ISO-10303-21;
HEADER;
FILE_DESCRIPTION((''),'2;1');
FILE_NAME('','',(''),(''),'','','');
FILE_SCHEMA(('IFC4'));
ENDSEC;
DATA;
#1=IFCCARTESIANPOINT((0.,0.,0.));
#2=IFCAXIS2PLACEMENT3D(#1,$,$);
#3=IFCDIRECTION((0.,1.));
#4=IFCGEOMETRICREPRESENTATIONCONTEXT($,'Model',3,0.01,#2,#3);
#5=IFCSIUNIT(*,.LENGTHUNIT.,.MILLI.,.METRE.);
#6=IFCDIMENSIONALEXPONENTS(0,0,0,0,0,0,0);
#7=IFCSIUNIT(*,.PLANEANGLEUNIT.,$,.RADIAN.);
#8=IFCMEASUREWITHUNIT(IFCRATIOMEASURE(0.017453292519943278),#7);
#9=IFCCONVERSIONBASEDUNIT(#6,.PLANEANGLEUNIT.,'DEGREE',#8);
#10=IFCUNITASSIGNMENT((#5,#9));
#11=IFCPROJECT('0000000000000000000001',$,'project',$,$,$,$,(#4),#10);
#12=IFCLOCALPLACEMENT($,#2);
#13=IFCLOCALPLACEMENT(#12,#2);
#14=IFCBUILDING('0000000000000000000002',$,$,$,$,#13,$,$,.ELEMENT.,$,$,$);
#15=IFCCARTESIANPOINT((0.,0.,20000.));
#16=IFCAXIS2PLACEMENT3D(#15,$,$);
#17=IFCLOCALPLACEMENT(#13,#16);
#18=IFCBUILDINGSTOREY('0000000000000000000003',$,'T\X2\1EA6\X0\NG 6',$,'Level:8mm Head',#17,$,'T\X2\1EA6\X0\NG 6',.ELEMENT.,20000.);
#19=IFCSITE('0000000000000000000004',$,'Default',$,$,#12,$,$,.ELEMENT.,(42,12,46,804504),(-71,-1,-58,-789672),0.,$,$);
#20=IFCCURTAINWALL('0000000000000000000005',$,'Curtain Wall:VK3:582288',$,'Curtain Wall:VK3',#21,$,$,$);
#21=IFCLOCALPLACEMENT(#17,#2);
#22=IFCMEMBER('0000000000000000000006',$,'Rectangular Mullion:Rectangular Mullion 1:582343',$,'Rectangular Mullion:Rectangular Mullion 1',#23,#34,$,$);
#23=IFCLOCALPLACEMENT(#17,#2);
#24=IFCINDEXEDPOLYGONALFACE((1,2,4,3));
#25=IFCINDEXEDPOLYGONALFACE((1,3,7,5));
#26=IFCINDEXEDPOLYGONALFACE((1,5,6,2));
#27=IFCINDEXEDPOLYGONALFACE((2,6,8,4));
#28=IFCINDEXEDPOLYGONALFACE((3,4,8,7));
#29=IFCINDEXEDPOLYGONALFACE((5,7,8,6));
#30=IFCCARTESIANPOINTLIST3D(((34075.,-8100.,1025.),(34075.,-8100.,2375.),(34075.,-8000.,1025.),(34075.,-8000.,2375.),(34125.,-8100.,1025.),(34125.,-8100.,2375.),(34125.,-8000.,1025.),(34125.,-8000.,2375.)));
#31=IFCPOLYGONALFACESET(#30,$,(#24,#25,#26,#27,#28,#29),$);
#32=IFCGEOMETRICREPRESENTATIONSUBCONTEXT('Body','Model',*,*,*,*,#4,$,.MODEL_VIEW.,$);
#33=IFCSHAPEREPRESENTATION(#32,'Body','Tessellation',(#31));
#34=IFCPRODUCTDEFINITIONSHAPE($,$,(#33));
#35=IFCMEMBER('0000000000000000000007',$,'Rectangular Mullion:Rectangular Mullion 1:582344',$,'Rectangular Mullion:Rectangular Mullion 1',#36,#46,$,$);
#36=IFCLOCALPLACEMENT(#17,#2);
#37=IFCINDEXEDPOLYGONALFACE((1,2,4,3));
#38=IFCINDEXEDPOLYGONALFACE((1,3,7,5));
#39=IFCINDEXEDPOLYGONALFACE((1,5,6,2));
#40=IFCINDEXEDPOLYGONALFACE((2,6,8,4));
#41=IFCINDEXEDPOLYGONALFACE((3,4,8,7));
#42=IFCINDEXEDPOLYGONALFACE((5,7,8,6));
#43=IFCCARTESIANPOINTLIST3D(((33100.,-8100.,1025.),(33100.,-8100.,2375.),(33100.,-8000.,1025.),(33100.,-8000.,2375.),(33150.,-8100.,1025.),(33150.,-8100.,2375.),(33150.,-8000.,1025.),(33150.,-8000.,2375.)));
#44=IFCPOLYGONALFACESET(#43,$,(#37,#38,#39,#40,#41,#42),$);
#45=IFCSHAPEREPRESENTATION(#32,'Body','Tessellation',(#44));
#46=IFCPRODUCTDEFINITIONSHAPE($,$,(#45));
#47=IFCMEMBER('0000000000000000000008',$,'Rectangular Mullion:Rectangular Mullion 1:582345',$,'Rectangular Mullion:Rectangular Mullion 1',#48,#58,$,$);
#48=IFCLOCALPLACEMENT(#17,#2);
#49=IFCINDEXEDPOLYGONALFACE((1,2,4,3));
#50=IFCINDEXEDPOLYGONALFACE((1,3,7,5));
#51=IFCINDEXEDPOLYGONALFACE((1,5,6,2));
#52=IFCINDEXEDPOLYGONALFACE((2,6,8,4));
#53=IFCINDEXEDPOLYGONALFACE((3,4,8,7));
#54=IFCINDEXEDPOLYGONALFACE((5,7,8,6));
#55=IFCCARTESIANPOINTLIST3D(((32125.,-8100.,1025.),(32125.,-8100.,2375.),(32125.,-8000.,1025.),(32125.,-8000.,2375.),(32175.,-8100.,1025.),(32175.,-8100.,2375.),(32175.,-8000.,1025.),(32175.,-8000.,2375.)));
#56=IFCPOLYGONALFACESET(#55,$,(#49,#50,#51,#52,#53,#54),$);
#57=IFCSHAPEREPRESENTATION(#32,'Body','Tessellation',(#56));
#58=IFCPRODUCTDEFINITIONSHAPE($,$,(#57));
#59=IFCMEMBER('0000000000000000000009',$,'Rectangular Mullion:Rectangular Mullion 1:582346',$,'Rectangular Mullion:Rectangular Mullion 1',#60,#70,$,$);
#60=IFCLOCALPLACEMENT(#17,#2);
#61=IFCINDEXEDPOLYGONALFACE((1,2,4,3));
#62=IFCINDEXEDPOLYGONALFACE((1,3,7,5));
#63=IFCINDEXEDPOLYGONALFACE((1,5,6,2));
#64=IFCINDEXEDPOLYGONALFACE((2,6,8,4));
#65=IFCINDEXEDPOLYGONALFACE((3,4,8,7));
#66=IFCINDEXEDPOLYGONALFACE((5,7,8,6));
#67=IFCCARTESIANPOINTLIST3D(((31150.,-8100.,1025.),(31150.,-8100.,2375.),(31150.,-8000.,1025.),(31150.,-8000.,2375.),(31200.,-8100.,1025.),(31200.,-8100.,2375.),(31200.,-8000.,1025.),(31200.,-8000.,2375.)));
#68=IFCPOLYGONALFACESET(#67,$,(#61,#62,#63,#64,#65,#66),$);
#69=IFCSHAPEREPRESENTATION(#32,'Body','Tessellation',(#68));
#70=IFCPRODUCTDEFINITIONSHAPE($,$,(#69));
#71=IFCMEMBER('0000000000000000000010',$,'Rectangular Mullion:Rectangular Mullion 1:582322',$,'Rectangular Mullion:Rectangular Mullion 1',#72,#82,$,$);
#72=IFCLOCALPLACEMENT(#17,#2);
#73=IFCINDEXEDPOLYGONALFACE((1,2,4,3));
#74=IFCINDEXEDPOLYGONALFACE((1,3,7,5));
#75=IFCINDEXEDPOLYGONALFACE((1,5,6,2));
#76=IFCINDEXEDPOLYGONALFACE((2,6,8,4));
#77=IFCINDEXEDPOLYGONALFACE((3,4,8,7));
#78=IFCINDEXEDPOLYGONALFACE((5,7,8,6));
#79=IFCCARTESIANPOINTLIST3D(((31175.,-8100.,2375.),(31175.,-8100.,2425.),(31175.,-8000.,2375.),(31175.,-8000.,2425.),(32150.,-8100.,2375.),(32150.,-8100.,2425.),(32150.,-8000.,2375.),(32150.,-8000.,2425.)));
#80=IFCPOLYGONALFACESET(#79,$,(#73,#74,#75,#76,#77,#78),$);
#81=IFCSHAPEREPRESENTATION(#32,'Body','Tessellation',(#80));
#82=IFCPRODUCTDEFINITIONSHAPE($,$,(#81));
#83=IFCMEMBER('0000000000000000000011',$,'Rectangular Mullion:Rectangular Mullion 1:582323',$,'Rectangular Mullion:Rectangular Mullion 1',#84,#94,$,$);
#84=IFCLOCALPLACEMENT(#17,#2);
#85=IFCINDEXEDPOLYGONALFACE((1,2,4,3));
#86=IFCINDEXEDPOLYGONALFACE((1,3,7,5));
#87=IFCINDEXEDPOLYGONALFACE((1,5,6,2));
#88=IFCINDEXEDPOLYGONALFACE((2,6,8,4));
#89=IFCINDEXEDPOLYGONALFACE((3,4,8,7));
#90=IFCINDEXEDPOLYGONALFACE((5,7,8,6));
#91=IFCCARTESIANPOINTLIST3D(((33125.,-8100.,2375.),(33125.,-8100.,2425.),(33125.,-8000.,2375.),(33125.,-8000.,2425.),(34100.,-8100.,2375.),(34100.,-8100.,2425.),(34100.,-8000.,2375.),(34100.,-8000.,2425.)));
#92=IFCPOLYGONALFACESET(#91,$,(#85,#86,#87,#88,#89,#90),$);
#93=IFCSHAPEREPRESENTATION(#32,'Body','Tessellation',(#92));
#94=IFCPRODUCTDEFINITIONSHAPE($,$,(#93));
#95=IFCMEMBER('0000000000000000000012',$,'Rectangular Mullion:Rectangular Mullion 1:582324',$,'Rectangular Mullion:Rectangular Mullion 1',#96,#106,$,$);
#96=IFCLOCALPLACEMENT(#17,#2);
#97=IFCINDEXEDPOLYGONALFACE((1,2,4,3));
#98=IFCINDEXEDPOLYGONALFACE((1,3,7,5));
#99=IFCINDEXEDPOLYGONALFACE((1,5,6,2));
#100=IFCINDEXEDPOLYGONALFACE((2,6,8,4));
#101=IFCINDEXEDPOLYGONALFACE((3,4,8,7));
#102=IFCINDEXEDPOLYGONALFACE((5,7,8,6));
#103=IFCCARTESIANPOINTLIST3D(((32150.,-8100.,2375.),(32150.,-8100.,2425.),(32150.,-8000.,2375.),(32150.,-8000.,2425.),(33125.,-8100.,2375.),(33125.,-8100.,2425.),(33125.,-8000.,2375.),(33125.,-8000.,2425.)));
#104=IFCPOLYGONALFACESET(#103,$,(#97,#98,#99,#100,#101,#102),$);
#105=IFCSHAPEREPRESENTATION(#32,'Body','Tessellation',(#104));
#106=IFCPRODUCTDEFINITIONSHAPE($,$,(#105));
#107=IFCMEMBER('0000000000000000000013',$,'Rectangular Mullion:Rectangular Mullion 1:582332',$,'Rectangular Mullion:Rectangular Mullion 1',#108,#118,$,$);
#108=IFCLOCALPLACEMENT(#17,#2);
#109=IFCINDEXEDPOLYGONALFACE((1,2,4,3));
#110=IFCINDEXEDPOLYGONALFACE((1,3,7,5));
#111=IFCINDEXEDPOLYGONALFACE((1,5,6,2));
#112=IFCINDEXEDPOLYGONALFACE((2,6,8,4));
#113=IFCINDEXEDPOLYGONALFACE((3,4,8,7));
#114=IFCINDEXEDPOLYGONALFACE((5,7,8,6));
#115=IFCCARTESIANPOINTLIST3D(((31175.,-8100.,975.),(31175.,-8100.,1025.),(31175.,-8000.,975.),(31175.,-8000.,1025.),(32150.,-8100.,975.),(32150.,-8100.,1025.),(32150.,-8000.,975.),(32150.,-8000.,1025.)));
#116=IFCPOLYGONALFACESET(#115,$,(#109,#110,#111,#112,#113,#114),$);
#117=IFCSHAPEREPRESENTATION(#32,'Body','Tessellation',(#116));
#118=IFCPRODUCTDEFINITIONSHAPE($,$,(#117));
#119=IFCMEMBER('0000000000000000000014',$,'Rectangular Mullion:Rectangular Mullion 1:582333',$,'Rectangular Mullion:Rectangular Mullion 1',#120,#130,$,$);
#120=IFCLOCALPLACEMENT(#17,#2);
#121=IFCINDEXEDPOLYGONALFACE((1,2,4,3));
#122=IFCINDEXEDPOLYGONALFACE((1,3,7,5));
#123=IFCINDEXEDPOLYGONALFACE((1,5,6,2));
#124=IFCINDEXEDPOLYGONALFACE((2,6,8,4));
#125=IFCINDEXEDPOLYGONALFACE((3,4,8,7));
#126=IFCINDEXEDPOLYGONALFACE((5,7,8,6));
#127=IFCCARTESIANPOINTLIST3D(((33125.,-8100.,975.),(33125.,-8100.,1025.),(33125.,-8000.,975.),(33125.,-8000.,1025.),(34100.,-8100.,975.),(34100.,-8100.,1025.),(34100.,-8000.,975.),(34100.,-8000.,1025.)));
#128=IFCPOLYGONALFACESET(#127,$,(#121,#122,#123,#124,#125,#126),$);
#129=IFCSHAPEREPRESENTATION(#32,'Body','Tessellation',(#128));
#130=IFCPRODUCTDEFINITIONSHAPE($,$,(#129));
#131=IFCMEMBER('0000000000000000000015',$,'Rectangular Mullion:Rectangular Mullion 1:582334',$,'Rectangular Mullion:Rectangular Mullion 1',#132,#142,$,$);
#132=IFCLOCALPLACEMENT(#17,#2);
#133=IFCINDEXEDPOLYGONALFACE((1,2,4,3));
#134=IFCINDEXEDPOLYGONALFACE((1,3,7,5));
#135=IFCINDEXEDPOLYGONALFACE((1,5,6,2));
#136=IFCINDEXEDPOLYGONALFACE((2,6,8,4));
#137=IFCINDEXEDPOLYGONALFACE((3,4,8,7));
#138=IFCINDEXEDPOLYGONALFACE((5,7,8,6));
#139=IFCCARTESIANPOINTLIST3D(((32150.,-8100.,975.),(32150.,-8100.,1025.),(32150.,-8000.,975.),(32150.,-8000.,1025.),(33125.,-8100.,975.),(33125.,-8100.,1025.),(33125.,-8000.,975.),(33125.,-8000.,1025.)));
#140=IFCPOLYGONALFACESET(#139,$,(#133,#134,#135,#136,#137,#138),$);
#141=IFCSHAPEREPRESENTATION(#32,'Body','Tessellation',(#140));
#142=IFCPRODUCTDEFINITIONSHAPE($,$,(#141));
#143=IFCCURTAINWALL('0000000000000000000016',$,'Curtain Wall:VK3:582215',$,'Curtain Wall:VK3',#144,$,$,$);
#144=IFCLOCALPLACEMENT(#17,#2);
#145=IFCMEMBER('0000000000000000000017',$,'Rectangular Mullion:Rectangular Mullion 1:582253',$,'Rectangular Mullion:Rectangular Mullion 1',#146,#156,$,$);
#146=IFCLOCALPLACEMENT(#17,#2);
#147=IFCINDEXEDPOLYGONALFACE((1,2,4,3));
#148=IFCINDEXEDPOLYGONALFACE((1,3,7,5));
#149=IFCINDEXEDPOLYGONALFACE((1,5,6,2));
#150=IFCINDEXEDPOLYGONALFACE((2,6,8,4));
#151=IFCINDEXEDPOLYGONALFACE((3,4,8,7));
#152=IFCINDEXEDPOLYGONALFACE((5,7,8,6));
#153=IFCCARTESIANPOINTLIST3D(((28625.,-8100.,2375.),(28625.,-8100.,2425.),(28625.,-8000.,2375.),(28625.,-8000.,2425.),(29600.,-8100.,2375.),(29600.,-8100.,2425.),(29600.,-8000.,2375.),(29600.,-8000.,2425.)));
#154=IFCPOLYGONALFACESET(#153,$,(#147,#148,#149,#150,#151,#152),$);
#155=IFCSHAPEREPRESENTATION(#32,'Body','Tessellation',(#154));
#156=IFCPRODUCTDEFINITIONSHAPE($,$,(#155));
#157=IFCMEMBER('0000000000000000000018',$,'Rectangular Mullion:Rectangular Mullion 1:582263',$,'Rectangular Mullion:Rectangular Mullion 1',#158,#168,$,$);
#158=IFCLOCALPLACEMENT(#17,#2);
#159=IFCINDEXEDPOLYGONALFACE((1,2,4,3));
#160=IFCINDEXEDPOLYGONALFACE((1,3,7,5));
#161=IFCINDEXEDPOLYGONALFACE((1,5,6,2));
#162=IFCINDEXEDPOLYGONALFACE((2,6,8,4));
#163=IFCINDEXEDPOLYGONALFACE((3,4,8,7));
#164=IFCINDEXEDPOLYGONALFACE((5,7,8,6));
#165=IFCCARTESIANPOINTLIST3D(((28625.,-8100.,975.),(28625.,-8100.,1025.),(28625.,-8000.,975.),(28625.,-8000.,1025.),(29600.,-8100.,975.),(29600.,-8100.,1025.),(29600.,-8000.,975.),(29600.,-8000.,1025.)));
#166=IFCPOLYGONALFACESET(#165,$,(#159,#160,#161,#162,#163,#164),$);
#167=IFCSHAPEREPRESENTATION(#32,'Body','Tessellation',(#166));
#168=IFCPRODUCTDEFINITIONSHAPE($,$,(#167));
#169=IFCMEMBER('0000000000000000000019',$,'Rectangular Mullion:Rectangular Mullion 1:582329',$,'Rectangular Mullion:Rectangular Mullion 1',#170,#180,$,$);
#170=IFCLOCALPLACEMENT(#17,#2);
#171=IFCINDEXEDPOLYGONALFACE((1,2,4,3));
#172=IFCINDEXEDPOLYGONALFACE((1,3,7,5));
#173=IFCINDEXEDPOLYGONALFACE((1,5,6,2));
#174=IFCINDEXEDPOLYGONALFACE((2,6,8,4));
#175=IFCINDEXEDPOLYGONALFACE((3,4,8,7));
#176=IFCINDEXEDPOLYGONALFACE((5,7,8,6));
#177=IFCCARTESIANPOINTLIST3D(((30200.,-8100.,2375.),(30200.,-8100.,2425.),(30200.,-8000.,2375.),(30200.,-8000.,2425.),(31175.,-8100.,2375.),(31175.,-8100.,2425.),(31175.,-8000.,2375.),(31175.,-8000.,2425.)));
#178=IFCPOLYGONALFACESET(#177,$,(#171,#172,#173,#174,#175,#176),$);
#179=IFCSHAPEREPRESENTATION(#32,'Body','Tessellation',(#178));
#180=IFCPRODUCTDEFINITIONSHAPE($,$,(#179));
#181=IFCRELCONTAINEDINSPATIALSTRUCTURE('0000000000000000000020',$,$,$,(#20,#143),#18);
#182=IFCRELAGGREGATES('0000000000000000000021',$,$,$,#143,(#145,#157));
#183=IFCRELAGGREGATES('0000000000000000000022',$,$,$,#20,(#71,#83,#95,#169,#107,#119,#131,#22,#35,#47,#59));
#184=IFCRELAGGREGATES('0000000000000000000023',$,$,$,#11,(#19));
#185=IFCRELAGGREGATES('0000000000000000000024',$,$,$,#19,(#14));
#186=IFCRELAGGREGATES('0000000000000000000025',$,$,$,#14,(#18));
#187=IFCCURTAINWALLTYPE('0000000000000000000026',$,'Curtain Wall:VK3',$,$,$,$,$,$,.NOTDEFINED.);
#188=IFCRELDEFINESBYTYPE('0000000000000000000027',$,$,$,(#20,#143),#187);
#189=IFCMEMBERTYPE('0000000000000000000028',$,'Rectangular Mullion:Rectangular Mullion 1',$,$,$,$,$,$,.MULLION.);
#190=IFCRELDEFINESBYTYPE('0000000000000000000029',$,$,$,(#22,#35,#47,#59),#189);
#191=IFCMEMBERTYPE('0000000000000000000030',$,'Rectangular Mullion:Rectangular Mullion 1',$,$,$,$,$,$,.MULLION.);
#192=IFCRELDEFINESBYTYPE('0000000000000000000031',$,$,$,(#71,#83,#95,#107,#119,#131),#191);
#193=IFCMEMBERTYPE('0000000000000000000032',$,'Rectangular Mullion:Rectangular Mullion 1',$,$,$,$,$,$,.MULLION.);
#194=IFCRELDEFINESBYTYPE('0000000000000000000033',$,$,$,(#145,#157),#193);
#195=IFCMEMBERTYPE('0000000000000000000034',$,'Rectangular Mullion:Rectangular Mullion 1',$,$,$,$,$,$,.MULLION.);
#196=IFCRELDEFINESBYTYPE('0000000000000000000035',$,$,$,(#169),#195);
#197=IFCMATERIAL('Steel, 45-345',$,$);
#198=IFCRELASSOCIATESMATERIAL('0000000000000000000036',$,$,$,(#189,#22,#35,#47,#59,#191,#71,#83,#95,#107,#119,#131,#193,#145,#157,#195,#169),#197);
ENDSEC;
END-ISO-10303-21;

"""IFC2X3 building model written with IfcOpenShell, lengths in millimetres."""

from ifc_helpers import new_model, entity, si_unit, converted_unit, direction, frame, origin, origin_2d_with_axis, place, context, subcontext, project, spatial, rectangle, extrude, source, transform, mapped, material, type_object, type_shapes, element, aggregate, save


model = new_model("IFC2X3")

# Units and contexts
model_context = context("Model", 3, precision=0.01, world=origin(), true_north=direction((0.0, 1.0)))
body_context = subcontext(model_context, "Body", "Model", "MODEL_VIEW")
ifc_project = project(units=[si_unit("LENGTHUNIT", "METRE", prefix="MILLI"), converted_unit("PLANEANGLEUNIT", "DEGREE", entity("IfcRatioMeasure", 0.017453292519943278), si_unit("PLANEANGLEUNIT", "RADIAN"), dimensions=[0, 0, 0, 0, 0, 0, 0])], contexts=[model_context])

# Site, building, storey
site_placement = place(None, origin())
site = spatial("IfcSite", under=ifc_project, at=site_placement, Name="Default", CompositionType="ELEMENT", RefLatitude=(42, 12, 46, 804504), RefLongitude=(-71, -1, -58, -789672), RefElevation=0.0)
building_placement = place(site_placement, origin())
building = spatial("IfcBuilding", under=site, at=building_placement, CompositionType="ELEMENT")
storey_placement = place(building_placement, frame((0.0, 0.0, 20000.0)))
storey = spatial("IfcBuildingStorey", under=building, at=storey_placement, Name="TẦNG 6", ObjectType="Level:8mm Head", LongName="TẦNG 6", CompositionType="ELEMENT", Elevation=20000.0)

# Curtain walls, members
curtain_wall_type = type_object("IfcCurtainWallType", Name="Curtain Wall:VK3", PredefinedType="NOTDEFINED")
curtain_wall_1_placement = place(storey_placement, frame((0.0, 0.0, -20000.0)))
curtain_wall_1 = element("IfcCurtainWall", 1, at=curtain_wall_1_placement, inside=storey, type_object=curtain_wall_type, Name="Curtain Wall:VK3:582288", ObjectType="Curtain Wall:VK3")
ifc_material_1 = material(Name="Steel, 45-345")
member_type_1 = type_object("IfcMemberType", Name="Rectangular Mullion:Rectangular Mullion 1", PredefinedType="MULLION", material=ifc_material_1)
shared_shape_1 = source(origin(), body_context, "Body", "SweptSolid", [
    extrude(rectangle(XDim=100.0, YDim=50.0, at=origin_2d_with_axis()), frame((0.0, 50.0, -1350.0), z_axis=(0.0, 0.0, 1.0), x_axis=(0.0, -1.0, 0.0)), (0.0, 0.0, 1.0), 1350.0),
])
type_shapes(member_type_1, [shared_shape_1])
member_1_placement = place(curtain_wall_1_placement, frame((34100.0, -8000.0, 21025.0), z_axis=(0.0, 0.0, -1.0), x_axis=(1.0, 0.0, 0.0)))
member_1 = element("IfcMember", 2, at=member_1_placement, type_object=member_type_1, material=ifc_material_1, Name="Rectangular Mullion:Rectangular Mullion 1:582343", ObjectType="Rectangular Mullion:Rectangular Mullion 1", context=body_context, shape_type="MappedRepresentation", body=[
    mapped(shared_shape_1, transform((0.0, 0.0, 0.0), scale=1.0)),
])
member_2_placement = place(curtain_wall_1_placement, frame((33125.0, -8000.0, 21025.0), z_axis=(0.0, 0.0, -1.0), x_axis=(1.0, 0.0, 0.0)))
member_2 = element("IfcMember", 3, at=member_2_placement, type_object=member_type_1, material=ifc_material_1, Name="Rectangular Mullion:Rectangular Mullion 1:582344", ObjectType="Rectangular Mullion:Rectangular Mullion 1", context=body_context, shape_type="MappedRepresentation", body=[
    mapped(shared_shape_1, transform((0.0, 0.0, 0.0), scale=1.0)),
])
member_3_placement = place(curtain_wall_1_placement, frame((32150.0, -8000.0, 21025.0), z_axis=(0.0, 0.0, -1.0), x_axis=(1.0, 0.0, 0.0)))
member_3 = element("IfcMember", 4, at=member_3_placement, type_object=member_type_1, material=ifc_material_1, Name="Rectangular Mullion:Rectangular Mullion 1:582345", ObjectType="Rectangular Mullion:Rectangular Mullion 1", context=body_context, shape_type="MappedRepresentation", body=[
    mapped(shared_shape_1, transform((0.0, 0.0, 0.0), scale=1.0)),
])
member_4_placement = place(curtain_wall_1_placement, frame((31175.0, -8000.0, 21025.0), z_axis=(0.0, 0.0, -1.0), x_axis=(1.0, 0.0, 0.0)))
member_4 = element("IfcMember", 5, at=member_4_placement, type_object=member_type_1, material=ifc_material_1, Name="Rectangular Mullion:Rectangular Mullion 1:582346", ObjectType="Rectangular Mullion:Rectangular Mullion 1", context=body_context, shape_type="MappedRepresentation", body=[
    mapped(shared_shape_1, transform((0.0, 0.0, 0.0), scale=1.0)),
])
member_type_2 = type_object("IfcMemberType", Name="Rectangular Mullion:Rectangular Mullion 1", PredefinedType="MULLION", material=ifc_material_1)
shared_shape_2 = source(origin(), body_context, "Body", "SweptSolid", [
    extrude(rectangle(XDim=100.0, YDim=50.0, at=origin_2d_with_axis()), frame((0.0, 50.0, -975.0), z_axis=(0.0, 0.0, 1.0), x_axis=(0.0, -1.0, 0.0)), (0.0, 0.0, 1.0), 975.0),
])
type_shapes(member_type_2, [shared_shape_2])
member_5_placement = place(curtain_wall_1_placement, frame((32150.0, -8000.0, 22400.0), z_axis=(1.0, 0.0, 0.0), x_axis=(0.0, 0.0, 1.0)))
member_5 = element("IfcMember", 6, at=member_5_placement, type_object=member_type_2, material=ifc_material_1, Name="Rectangular Mullion:Rectangular Mullion 1:582322", ObjectType="Rectangular Mullion:Rectangular Mullion 1", context=body_context, shape_type="MappedRepresentation", body=[
    mapped(shared_shape_2, transform((0.0, 0.0, 0.0), scale=1.0)),
])
member_6_placement = place(curtain_wall_1_placement, frame((34100.0, -8000.0, 22400.0), z_axis=(1.0, 0.0, 0.0), x_axis=(0.0, 0.0, 1.0)))
member_6 = element("IfcMember", 7, at=member_6_placement, type_object=member_type_2, material=ifc_material_1, Name="Rectangular Mullion:Rectangular Mullion 1:582323", ObjectType="Rectangular Mullion:Rectangular Mullion 1", context=body_context, shape_type="MappedRepresentation", body=[
    mapped(shared_shape_2, transform((0.0, 0.0, 0.0), scale=1.0)),
])
member_7_placement = place(curtain_wall_1_placement, frame((33125.0, -8000.0, 22400.0), z_axis=(1.0, 0.0, 0.0), x_axis=(0.0, 0.0, 1.0)))
member_7 = element("IfcMember", 8, at=member_7_placement, type_object=member_type_2, material=ifc_material_1, Name="Rectangular Mullion:Rectangular Mullion 1:582324", ObjectType="Rectangular Mullion:Rectangular Mullion 1", context=body_context, shape_type="MappedRepresentation", body=[
    mapped(shared_shape_2, transform((0.0, 0.0, 0.0), scale=1.0)),
])
member_8_placement = place(curtain_wall_1_placement, frame((32150.0, -8000.0, 21000.0), z_axis=(1.0, 0.0, 0.0), x_axis=(0.0, 0.0, 1.0)))
member_8 = element("IfcMember", 9, at=member_8_placement, type_object=member_type_2, material=ifc_material_1, Name="Rectangular Mullion:Rectangular Mullion 1:582332", ObjectType="Rectangular Mullion:Rectangular Mullion 1", context=body_context, shape_type="MappedRepresentation", body=[
    mapped(shared_shape_2, transform((0.0, 0.0, 0.0), scale=1.0)),
])
member_9_placement = place(curtain_wall_1_placement, frame((34100.0, -8000.0, 21000.0), z_axis=(1.0, 0.0, 0.0), x_axis=(0.0, 0.0, 1.0)))
member_9 = element("IfcMember", 10, at=member_9_placement, type_object=member_type_2, material=ifc_material_1, Name="Rectangular Mullion:Rectangular Mullion 1:582333", ObjectType="Rectangular Mullion:Rectangular Mullion 1", context=body_context, shape_type="MappedRepresentation", body=[
    mapped(shared_shape_2, transform((0.0, 0.0, 0.0), scale=1.0)),
])
member_10_placement = place(curtain_wall_1_placement, frame((33125.0, -8000.0, 21000.0), z_axis=(1.0, 0.0, 0.0), x_axis=(0.0, 0.0, 1.0)))
member_10 = element("IfcMember", 11, at=member_10_placement, type_object=member_type_2, material=ifc_material_1, Name="Rectangular Mullion:Rectangular Mullion 1:582334", ObjectType="Rectangular Mullion:Rectangular Mullion 1", context=body_context, shape_type="MappedRepresentation", body=[
    mapped(shared_shape_2, transform((0.0, 0.0, 0.0), scale=1.0)),
])
curtain_wall_2_placement = place(storey_placement, frame((0.0, 0.0, -20000.0)))
curtain_wall_2 = element("IfcCurtainWall", 12, at=curtain_wall_2_placement, inside=storey, type_object=curtain_wall_type, Name="Curtain Wall:VK3:582215", ObjectType="Curtain Wall:VK3")
member_type_3 = type_object("IfcMemberType", Name="Rectangular Mullion:Rectangular Mullion 1", PredefinedType="MULLION", material=ifc_material_1)
shared_shape_3 = source(origin(), body_context, "Body", "SweptSolid", [
    extrude(rectangle(XDim=100.0, YDim=50.0, at=origin_2d_with_axis()), frame((0.0, 50.0, -975.0), z_axis=(0.0, 0.0, 1.0), x_axis=(0.0, -1.0, 0.0)), (0.0, 0.0, 1.0), 975.0),
])
type_shapes(member_type_3, [shared_shape_3])
member_11_placement = place(curtain_wall_2_placement, frame((29600.0, -8000.0, 22400.0), z_axis=(1.0, 0.0, 0.0), x_axis=(0.0, 0.0, 1.0)))
member_11 = element("IfcMember", 13, at=member_11_placement, type_object=member_type_3, material=ifc_material_1, Name="Rectangular Mullion:Rectangular Mullion 1:582253", ObjectType="Rectangular Mullion:Rectangular Mullion 1", context=body_context, shape_type="MappedRepresentation", body=[
    mapped(shared_shape_3, transform((0.0, 0.0, 0.0), scale=1.0)),
])
member_12_placement = place(curtain_wall_2_placement, frame((29600.0, -8000.0, 21000.0), z_axis=(1.0, 0.0, 0.0), x_axis=(0.0, 0.0, 1.0)))
member_12 = element("IfcMember", 14, at=member_12_placement, type_object=member_type_3, material=ifc_material_1, Name="Rectangular Mullion:Rectangular Mullion 1:582263", ObjectType="Rectangular Mullion:Rectangular Mullion 1", context=body_context, shape_type="MappedRepresentation", body=[
    mapped(shared_shape_3, transform((0.0, 0.0, 0.0), scale=1.0)),
])

# Member
member_type_4 = type_object("IfcMemberType", Name="Rectangular Mullion:Rectangular Mullion 1", PredefinedType="MULLION", material=ifc_material_1)
shared_shape_4 = source(origin(), body_context, "Body", "SweptSolid", [
    extrude(rectangle(XDim=100.0, YDim=50.0, at=origin_2d_with_axis()), frame((0.0, 50.0, -975.0), z_axis=(0.0, 0.0, 1.0), x_axis=(0.0, -1.0, 0.0)), (0.0, 0.0, 1.0), 975.0),
])
type_shapes(member_type_4, [shared_shape_4])
member_13_placement = place(curtain_wall_1_placement, frame((31175.0, -8000.0, 22400.0), z_axis=(1.0, 0.0, 0.0), x_axis=(0.0, 0.0, 1.0)))
member_13 = element("IfcMember", 15, at=member_13_placement, type_object=member_type_4, material=ifc_material_1, Name="Rectangular Mullion:Rectangular Mullion 1:582329", ObjectType="Rectangular Mullion:Rectangular Mullion 1", context=body_context, shape_type="MappedRepresentation", body=[
    mapped(shared_shape_4, transform((0.0, 0.0, 0.0), scale=1.0)),
])

aggregate(curtain_wall_2, [member_11, member_12])
aggregate(curtain_wall_1, [member_5, member_6, member_7, member_13, member_8, member_9, member_10, member_1, member_2, member_3, member_4])

save(model, "model.ifc")
